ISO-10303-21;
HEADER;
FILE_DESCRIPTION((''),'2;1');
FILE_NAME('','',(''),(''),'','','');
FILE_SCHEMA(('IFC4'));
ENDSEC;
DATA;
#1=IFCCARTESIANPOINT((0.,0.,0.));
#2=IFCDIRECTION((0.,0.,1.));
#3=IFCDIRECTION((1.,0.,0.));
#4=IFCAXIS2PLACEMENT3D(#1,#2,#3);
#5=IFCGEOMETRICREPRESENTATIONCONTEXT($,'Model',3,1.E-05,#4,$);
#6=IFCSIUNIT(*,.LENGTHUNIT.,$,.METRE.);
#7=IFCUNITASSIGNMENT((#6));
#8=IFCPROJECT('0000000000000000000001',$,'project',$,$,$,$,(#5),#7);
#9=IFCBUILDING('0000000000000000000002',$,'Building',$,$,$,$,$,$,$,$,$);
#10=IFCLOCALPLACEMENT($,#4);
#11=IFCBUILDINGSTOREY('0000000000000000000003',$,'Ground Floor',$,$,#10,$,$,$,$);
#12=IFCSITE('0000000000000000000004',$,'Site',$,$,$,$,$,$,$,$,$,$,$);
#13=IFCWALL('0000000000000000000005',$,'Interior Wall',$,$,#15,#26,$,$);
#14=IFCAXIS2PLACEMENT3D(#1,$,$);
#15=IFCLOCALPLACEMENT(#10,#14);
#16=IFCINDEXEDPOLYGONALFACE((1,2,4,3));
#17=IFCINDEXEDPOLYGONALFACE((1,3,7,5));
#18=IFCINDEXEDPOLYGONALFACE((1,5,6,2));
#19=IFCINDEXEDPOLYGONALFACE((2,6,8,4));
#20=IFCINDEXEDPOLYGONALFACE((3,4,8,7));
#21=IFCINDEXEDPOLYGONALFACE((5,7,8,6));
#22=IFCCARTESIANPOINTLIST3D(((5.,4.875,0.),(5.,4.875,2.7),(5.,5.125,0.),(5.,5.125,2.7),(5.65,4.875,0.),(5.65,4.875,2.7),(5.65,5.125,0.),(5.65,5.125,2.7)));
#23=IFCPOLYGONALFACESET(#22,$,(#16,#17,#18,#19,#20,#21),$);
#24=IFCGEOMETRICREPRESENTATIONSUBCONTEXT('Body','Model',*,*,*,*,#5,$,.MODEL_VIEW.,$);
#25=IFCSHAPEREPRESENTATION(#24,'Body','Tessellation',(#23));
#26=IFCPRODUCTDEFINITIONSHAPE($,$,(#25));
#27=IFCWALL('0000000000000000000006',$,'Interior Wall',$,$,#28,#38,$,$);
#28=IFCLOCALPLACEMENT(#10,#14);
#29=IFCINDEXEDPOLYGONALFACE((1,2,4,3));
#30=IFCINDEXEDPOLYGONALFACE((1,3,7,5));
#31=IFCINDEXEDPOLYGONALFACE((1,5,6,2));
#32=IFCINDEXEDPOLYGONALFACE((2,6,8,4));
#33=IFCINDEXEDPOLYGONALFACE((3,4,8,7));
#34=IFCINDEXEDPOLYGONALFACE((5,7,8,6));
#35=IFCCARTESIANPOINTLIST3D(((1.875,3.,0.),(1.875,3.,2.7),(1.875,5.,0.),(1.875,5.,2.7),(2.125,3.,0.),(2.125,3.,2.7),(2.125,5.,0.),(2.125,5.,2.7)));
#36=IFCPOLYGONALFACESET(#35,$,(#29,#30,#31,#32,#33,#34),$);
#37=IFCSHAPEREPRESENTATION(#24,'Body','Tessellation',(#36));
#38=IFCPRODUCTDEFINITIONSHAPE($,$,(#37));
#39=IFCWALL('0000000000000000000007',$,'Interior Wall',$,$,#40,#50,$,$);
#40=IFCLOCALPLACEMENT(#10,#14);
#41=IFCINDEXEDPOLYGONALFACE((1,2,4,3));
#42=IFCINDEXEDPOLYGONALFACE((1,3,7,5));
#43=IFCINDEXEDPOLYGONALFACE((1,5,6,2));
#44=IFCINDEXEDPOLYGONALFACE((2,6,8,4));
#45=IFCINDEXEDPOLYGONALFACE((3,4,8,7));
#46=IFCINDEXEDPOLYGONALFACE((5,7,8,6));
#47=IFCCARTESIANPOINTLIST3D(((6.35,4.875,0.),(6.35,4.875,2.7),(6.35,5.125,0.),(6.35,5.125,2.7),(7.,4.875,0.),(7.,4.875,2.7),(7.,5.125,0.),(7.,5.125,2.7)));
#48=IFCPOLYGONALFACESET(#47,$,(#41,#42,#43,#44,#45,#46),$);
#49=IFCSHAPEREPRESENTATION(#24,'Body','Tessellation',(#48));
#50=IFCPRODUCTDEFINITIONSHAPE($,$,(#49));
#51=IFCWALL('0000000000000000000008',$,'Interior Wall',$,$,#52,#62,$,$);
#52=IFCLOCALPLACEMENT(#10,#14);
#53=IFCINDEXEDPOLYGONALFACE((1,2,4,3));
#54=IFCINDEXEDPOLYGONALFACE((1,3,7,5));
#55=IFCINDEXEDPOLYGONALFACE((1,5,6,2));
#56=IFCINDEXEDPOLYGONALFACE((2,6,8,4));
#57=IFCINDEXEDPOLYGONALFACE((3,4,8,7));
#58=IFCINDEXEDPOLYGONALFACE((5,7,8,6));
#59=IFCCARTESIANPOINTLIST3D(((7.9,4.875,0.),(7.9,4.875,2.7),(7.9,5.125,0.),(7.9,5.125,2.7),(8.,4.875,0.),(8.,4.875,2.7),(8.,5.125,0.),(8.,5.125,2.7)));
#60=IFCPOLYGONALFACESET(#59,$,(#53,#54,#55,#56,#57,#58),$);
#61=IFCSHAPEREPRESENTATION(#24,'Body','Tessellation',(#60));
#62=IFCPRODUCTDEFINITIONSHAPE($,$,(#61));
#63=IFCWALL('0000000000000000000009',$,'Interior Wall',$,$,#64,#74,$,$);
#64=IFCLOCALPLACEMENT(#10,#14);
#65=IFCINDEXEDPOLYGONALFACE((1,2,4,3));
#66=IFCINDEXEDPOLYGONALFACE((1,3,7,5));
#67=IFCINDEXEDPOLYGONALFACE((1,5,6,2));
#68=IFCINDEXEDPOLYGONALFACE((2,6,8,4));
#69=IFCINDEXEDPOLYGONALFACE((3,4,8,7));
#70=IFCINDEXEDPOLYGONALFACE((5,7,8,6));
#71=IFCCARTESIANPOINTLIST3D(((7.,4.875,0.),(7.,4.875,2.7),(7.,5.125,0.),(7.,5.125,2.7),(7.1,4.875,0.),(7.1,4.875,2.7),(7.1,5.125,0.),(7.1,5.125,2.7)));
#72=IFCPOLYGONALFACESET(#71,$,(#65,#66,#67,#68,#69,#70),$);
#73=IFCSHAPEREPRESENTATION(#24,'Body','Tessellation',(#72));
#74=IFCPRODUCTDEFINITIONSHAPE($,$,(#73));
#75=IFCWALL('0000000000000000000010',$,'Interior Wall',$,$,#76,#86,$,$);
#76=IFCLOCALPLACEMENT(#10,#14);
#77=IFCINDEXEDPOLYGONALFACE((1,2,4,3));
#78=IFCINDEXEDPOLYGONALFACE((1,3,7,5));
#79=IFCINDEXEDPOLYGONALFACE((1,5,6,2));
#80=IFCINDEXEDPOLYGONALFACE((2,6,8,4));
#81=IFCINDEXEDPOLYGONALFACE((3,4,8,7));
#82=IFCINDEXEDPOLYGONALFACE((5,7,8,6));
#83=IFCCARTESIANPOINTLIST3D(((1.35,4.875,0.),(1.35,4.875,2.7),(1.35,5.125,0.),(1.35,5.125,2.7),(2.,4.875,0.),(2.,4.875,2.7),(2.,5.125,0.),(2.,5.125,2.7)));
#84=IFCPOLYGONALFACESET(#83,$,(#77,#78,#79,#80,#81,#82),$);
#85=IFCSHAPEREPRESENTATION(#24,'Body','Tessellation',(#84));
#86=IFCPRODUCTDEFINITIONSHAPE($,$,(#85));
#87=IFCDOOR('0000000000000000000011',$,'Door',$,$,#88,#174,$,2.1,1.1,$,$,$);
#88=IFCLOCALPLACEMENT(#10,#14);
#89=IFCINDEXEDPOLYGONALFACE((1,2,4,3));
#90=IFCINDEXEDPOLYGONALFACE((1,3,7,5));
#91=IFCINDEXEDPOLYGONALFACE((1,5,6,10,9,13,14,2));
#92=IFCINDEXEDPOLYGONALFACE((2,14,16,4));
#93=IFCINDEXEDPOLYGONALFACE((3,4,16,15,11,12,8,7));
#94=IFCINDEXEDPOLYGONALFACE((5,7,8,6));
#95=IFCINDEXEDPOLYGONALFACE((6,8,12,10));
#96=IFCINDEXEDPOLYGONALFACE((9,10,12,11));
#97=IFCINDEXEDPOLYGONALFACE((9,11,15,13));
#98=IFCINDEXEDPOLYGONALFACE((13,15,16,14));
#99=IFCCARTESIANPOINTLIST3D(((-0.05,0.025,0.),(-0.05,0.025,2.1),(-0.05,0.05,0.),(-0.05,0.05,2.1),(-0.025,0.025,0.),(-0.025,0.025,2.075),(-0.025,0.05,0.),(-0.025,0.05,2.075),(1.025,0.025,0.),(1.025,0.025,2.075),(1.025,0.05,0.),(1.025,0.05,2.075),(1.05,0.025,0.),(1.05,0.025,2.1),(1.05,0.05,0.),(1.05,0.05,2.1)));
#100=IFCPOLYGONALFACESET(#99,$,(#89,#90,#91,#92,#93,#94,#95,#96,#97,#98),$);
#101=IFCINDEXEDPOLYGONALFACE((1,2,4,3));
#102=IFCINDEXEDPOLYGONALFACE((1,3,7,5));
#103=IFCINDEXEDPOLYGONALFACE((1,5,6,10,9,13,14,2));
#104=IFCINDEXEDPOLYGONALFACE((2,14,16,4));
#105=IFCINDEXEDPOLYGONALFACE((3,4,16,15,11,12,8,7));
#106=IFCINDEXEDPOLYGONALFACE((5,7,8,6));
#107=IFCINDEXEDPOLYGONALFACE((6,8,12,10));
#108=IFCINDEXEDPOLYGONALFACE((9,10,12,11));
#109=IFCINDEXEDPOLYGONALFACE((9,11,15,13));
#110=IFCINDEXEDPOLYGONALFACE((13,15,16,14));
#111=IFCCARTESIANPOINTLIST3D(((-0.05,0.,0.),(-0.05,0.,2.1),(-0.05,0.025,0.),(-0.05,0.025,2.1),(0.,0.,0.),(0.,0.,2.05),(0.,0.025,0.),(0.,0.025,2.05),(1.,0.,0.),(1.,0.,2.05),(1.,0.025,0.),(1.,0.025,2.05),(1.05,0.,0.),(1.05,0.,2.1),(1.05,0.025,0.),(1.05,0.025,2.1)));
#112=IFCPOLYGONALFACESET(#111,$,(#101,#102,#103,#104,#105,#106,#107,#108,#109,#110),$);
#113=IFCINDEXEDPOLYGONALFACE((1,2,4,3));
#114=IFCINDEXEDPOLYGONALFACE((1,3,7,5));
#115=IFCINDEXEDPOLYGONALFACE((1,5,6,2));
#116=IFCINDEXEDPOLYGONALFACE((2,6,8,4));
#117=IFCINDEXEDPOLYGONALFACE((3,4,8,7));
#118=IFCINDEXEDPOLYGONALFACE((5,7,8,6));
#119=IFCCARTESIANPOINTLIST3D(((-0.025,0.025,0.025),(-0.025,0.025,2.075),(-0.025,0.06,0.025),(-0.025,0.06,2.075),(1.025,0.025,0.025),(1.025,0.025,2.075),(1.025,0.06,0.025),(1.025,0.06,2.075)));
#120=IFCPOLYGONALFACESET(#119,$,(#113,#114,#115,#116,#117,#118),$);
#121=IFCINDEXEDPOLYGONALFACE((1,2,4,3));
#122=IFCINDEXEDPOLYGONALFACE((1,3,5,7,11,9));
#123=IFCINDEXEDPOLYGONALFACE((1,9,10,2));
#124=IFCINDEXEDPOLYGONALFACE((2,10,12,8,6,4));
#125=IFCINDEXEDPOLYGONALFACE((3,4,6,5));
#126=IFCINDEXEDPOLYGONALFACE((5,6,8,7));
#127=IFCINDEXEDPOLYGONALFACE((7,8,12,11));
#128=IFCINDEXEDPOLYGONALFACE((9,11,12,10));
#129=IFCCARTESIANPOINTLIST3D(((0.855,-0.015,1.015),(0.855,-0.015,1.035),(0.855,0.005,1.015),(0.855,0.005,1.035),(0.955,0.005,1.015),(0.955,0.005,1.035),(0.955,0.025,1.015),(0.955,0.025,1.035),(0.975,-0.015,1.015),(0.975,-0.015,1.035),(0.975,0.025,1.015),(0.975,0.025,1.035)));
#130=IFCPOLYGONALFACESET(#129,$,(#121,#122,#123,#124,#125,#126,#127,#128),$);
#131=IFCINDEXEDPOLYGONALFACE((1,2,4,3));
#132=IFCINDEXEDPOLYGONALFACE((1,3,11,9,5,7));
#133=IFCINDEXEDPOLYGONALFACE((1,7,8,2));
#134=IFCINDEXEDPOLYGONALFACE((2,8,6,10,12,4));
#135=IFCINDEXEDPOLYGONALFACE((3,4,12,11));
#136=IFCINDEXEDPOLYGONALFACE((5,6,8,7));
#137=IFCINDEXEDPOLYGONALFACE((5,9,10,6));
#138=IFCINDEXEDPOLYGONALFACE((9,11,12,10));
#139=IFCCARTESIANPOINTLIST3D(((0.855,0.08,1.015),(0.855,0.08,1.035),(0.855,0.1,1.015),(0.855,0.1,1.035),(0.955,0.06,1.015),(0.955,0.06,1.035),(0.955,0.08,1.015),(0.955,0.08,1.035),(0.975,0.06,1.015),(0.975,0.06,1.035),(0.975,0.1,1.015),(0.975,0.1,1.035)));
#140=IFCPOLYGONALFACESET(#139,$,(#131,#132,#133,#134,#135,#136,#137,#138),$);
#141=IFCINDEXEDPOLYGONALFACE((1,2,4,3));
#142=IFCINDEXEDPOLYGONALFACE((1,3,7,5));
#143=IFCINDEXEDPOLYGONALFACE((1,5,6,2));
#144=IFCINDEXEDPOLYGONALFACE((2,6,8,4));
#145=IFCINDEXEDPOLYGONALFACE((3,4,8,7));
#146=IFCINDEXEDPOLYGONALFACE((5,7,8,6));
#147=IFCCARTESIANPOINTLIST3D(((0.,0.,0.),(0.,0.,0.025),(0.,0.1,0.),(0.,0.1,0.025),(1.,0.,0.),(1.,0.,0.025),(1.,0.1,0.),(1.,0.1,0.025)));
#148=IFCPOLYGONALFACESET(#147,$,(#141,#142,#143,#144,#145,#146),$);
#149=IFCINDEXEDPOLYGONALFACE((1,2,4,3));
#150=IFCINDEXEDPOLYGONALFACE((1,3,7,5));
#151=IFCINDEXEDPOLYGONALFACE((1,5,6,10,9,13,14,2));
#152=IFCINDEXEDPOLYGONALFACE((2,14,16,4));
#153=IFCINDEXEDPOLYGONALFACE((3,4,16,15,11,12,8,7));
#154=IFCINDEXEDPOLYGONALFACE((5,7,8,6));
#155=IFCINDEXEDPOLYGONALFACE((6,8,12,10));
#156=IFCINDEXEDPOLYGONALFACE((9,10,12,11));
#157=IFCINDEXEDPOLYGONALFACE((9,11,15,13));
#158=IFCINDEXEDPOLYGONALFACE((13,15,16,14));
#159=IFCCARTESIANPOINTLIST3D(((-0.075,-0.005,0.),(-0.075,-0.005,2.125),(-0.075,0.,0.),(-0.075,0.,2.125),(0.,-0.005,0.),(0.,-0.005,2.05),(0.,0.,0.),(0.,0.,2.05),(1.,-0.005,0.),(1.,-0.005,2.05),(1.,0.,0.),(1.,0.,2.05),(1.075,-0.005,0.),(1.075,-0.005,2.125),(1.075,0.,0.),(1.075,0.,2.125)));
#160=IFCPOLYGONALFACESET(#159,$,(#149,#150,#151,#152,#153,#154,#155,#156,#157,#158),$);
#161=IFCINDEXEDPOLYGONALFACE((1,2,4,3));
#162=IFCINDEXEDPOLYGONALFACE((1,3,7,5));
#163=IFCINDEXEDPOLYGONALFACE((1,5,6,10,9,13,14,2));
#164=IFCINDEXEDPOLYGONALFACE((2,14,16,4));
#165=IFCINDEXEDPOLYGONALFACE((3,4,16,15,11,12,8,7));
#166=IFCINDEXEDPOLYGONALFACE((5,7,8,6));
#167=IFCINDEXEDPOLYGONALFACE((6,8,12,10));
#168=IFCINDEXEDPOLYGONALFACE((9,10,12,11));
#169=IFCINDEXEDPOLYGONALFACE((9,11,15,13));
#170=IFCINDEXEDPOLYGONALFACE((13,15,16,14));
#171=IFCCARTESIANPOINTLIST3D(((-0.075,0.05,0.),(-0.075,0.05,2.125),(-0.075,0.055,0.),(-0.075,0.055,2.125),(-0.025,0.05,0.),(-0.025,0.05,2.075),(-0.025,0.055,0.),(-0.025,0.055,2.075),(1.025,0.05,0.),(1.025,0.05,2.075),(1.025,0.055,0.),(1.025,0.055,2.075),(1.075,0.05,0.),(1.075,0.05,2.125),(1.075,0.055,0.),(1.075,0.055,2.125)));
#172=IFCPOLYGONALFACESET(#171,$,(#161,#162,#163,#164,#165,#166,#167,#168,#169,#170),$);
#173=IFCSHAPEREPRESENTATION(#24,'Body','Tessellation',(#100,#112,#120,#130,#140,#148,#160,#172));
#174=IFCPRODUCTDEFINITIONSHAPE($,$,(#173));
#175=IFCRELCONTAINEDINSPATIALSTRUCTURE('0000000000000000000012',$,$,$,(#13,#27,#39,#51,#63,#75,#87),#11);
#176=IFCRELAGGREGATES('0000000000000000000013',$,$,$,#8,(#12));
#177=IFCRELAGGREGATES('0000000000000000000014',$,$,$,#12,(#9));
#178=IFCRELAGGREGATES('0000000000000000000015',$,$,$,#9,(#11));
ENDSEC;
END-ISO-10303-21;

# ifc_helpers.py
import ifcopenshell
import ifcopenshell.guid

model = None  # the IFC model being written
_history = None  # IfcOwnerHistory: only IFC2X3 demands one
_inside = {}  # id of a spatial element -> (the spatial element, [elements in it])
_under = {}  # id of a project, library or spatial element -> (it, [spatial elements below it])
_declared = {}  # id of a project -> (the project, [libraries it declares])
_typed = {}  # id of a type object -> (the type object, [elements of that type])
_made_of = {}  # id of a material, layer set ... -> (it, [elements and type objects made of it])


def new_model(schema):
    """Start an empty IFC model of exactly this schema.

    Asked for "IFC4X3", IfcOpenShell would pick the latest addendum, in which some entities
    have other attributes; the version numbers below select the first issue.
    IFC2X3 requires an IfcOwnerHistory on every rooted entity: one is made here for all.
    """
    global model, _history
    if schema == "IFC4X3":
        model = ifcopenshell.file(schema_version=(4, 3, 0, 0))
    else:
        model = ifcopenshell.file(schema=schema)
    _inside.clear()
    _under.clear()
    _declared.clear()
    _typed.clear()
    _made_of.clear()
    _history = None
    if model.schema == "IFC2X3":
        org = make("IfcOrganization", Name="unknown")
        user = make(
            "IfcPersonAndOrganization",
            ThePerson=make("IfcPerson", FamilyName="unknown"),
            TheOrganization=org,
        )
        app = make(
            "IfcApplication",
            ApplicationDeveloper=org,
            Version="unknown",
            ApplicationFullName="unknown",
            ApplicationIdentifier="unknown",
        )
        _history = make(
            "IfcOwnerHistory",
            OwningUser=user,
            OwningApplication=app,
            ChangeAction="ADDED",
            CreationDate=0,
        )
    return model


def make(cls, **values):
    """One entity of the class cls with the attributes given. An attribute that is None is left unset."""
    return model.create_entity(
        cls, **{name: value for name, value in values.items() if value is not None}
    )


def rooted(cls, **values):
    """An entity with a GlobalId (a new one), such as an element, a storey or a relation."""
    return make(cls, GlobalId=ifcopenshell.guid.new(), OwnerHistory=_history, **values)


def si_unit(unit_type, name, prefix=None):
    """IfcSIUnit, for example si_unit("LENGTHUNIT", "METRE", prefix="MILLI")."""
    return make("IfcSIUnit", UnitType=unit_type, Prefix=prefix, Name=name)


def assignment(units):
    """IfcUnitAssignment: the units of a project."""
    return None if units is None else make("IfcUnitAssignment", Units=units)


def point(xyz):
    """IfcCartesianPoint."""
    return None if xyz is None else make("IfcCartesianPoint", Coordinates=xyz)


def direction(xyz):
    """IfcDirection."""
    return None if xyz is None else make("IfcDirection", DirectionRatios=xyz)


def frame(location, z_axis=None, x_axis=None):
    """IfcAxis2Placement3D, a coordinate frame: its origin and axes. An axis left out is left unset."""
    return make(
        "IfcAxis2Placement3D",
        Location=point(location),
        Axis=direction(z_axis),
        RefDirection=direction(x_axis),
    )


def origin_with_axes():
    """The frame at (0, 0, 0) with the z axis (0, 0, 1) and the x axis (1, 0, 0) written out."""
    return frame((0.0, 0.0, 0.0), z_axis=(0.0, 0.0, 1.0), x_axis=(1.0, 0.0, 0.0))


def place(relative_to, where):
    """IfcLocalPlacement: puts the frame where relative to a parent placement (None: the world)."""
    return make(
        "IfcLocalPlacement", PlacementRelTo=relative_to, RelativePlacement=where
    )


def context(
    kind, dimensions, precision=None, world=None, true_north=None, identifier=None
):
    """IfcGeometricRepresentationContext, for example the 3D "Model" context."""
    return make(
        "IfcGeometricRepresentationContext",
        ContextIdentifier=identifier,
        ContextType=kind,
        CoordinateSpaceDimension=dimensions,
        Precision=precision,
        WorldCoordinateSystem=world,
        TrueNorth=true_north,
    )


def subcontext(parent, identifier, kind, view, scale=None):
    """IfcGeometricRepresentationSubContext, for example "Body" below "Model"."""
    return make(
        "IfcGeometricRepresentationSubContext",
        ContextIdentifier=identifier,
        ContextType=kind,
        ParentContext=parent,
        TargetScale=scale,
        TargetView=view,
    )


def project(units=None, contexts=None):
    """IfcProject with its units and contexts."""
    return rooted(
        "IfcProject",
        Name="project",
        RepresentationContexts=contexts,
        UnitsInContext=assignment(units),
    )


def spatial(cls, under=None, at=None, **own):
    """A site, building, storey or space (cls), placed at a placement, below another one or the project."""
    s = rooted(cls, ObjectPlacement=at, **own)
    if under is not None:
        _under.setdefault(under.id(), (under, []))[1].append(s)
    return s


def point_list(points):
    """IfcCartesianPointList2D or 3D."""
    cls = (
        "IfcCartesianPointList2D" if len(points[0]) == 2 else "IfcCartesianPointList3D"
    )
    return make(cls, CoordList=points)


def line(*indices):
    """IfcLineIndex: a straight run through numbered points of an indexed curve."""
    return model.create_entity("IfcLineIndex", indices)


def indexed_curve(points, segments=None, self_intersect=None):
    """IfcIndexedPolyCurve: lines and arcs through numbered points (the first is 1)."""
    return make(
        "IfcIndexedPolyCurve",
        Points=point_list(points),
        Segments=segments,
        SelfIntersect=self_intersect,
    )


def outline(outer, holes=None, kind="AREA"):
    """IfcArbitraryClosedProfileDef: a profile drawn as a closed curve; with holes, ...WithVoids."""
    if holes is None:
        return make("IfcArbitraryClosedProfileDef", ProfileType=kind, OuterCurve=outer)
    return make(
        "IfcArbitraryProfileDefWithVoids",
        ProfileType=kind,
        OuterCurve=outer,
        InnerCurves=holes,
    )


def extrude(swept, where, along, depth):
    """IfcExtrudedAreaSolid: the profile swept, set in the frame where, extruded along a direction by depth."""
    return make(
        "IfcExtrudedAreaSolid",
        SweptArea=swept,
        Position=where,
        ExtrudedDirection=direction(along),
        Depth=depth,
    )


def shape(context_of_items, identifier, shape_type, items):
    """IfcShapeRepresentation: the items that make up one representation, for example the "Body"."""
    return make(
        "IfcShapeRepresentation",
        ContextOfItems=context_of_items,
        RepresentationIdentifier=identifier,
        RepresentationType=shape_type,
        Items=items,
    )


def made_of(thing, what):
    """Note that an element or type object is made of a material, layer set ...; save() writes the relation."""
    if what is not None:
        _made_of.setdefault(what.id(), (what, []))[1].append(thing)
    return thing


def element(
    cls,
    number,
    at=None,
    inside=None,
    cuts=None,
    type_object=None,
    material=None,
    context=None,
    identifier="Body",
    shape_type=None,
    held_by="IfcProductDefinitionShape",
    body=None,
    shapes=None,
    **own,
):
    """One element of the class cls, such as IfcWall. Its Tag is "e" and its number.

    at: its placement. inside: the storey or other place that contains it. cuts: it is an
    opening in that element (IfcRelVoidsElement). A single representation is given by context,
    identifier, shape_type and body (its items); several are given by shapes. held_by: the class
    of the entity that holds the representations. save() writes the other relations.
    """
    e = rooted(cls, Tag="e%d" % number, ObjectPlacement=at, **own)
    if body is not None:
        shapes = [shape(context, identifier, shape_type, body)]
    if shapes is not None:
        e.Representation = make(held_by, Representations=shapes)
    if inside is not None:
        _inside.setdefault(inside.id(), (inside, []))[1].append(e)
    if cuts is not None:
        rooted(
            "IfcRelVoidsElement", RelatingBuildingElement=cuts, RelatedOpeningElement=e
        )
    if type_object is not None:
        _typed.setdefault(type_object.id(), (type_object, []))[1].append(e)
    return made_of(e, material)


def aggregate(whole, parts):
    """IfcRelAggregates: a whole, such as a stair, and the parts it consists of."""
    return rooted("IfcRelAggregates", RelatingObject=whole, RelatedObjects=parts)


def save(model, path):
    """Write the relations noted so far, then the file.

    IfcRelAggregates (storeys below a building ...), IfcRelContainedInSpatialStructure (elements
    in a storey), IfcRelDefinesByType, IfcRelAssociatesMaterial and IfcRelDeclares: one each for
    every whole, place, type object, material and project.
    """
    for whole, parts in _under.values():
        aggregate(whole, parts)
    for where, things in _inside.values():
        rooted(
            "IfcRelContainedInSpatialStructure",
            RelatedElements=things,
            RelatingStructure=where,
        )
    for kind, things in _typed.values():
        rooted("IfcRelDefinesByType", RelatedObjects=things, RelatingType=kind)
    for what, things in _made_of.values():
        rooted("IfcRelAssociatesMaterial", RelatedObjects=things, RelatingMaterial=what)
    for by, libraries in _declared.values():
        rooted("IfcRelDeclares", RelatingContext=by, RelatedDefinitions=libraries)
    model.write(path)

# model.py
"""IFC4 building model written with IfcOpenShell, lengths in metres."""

from ifc_helpers import new_model, si_unit, frame, origin_with_axes, place, context, subcontext, project, spatial, line, indexed_curve, outline, extrude, element, save


model = new_model("IFC4")

# Units and contexts
model_context = context("Model", 3, precision=1e-05, world=origin_with_axes())
body_context = subcontext(model_context, "Body", "Model", "MODEL_VIEW")
ifc_project = project(units=[si_unit("LENGTHUNIT", "METRE")], contexts=[model_context])

# Site, building, storey
site = spatial("IfcSite", under=ifc_project, Name="Site")
building = spatial("IfcBuilding", under=site, Name="Building")
storey_placement = place(None, origin_with_axes())
storey = spatial("IfcBuildingStorey", under=building, at=storey_placement, Name="Ground Floor")

# Walls
wall_1_placement = place(storey_placement, frame((5.65, 5.0, 0.0), z_axis=(0.0, 0.0, 1.0), x_axis=(-1.0, 0.0, 0.0)))
element("IfcWall", 1, at=wall_1_placement, inside=storey, Name="Interior Wall", context=body_context, shape_type="SweptSolid", body=[
    extrude(outline(indexed_curve([(0.0, 0.0), (0.0, 0.25), (0.65, 0.25), (0.65, 0.0), (0.0, 0.0)], self_intersect=False)), frame((0.0, -0.125, 0.0), z_axis=(0.0, 0.0, 1.0), x_axis=(1.0, 0.0, 0.0)), (0.0, 0.0, 1.0), 2.7),
])
wall_2_placement = place(storey_placement, frame((2.0, 5.0, 0.0), z_axis=(0.0, 0.0, 1.0), x_axis=(0.0, -1.0, 0.0)))
element("IfcWall", 2, at=wall_2_placement, inside=storey, Name="Interior Wall", context=body_context, shape_type="SweptSolid", body=[
    extrude(outline(indexed_curve([(0.0, 0.0), (0.0, 0.25), (2.0, 0.25), (2.0, 0.0), (0.0, 0.0)], self_intersect=False)), frame((0.0, -0.125, 0.0), z_axis=(0.0, 0.0, 1.0), x_axis=(1.0, 0.0, 0.0)), (0.0, 0.0, 1.0), 2.7),
])
wall_3_placement = place(storey_placement, frame((7.0, 5.0, 0.0), z_axis=(0.0, 0.0, 1.0), x_axis=(-1.0, 0.0, 0.0)))
element("IfcWall", 3, at=wall_3_placement, inside=storey, Name="Interior Wall", context=body_context, shape_type="SweptSolid", body=[
    extrude(outline(indexed_curve([(0.0, 0.0), (0.0, 0.25), (0.65, 0.25), (0.65, 0.0), (0.0, 0.0)], self_intersect=False)), frame((0.0, -0.125, 0.0), z_axis=(0.0, 0.0, 1.0), x_axis=(1.0, 0.0, 0.0)), (0.0, 0.0, 1.0), 2.7),
])
for number, where, z_axis, x_axis, name in (
    (4, (8.0, 5.0, 0.0), (0.0, 0.0, 1.0), (-1.0, 0.0, 0.0), "Interior Wall"),
    (5, (7.1, 5.0, 0.0), (0.0, 0.0, 1.0), (-1.0, 0.0, 0.0), "Interior Wall"),
):
    element("IfcWall", number, at=place(storey_placement, frame(where, z_axis=z_axis, x_axis=x_axis)), inside=storey, Name=name, context=body_context, shape_type="SweptSolid", body=[
        extrude(outline(indexed_curve([(0.0, 0.0), (0.0, 0.25), (0.1, 0.25), (0.1, 0.0), (0.0, 0.0)], self_intersect=False)), frame((0.0, -0.125, 0.0), z_axis=(0.0, 0.0, 1.0), x_axis=(1.0, 0.0, 0.0)), (0.0, 0.0, 1.0), 2.7),
    ])
wall_4_placement = place(storey_placement, frame((2.0, 5.0, 0.0), z_axis=(0.0, 0.0, 1.0), x_axis=(-1.0, 0.0, 0.0)))
element("IfcWall", 6, at=wall_4_placement, inside=storey, Name="Interior Wall", context=body_context, shape_type="SweptSolid", body=[
    extrude(outline(indexed_curve([(0.0, 0.0), (0.0, 0.25), (0.65, 0.25), (0.65, 0.0), (0.0, 0.0)], self_intersect=False)), frame((0.0, -0.125, 0.0), z_axis=(0.0, 0.0, 1.0), x_axis=(1.0, 0.0, 0.0)), (0.0, 0.0, 1.0), 2.7),
])

# Door
door_1_placement = place(storey_placement, frame((-0.05, 0.0, 0.0), z_axis=(0.0, 0.0, 1.0), x_axis=(1.0, 0.0, 0.0)))
element("IfcDoor", 7, at=door_1_placement, inside=storey, Name="Door", OverallHeight=2.1, OverallWidth=1.1, context=body_context, shape_type="SweptSolid", body=[
    extrude(outline(indexed_curve([(0.0, 0.0), (0.0, 2.1), (1.1, 2.1), (1.1, 0.0), (1.075, 0.0), (1.075, 2.075), (0.025, 2.075), (0.025, 0.0)], segments=[line(1, 2, 3, 4, 5, 6, 7, 8, 1)])), frame((0.0, 0.025, 0.0), z_axis=(0.0, -1.0, 0.0), x_axis=(1.0, 0.0, 0.0)), (0.0, 0.0, -1.0), 0.025),
    extrude(outline(indexed_curve([(0.0, 0.0), (0.0, 2.1), (1.1, 2.1), (1.1, 0.0), (1.05, 0.0), (1.05, 2.05), (0.05, 2.05), (0.05, 0.0)], segments=[line(1, 2, 3, 4, 5, 6, 7, 8, 1)])), frame((0.0, 0.0, 0.0), z_axis=(0.0, -1.0, 0.0), x_axis=(1.0, 0.0, 0.0)), (0.0, 0.0, -1.0), 0.025),
    extrude(outline(indexed_curve([(0.0, 0.0), (1.05, 0.0), (1.05, 0.035), (0.0, 0.035)], segments=[line(1, 2, 3, 4, 1)])), frame((0.025, 0.025, 0.025), z_axis=(0.0, 0.0, 1.0), x_axis=(1.0, 0.0, 0.0)), (0.0, 0.0, 1.0), 2.05),
    extrude(outline(indexed_curve([(0.0, 0.0), (0.0, -0.04), (-0.12, -0.04), (-0.12, -0.02), (-0.02, -0.02), (-0.02, 0.0)], segments=[line(1, 2, 3, 4, 5, 6, 1)])), frame((1.025, 0.025, 1.015), z_axis=(0.0, 0.0, 1.0), x_axis=(1.0, 0.0, 0.0)), (0.0, 0.0, 1.0), 0.02),
    extrude(outline(indexed_curve([(0.0, 0.0), (0.0, 0.04), (-0.12, 0.04), (-0.12, 0.02), (-0.02, 0.02), (-0.02, 0.0)], segments=[line(1, 2, 3, 4, 5, 6, 1)])), frame((1.025, 0.06, 1.015), z_axis=(0.0, 0.0, 1.0), x_axis=(1.0, 0.0, 0.0)), (0.0, 0.0, 1.0), 0.02),
    extrude(outline(indexed_curve([(0.0, 0.0), (1.0, 0.0), (1.0, 0.1), (0.0, 0.1)], segments=[line(1, 2, 3, 4, 1)])), frame((0.05, 0.0, 0.0), z_axis=(0.0, 0.0, 1.0), x_axis=(1.0, 0.0, 0.0)), (0.0, 0.0, 1.0), 0.025),
    extrude(outline(indexed_curve([(0.0, 0.0), (0.0, 2.125), (1.15, 2.125), (1.15, 0.0), (1.075, 0.0), (1.075, 2.05), (0.075, 2.05), (0.075, 0.0)], segments=[line(1, 2, 3, 4, 5, 6, 7, 8, 1)])), frame((-0.025, -0.005, 0.0), z_axis=(0.0, -1.0, 0.0), x_axis=(1.0, 0.0, 0.0)), (0.0, 0.0, -1.0), 0.005),
    extrude(outline(indexed_curve([(0.0, 0.0), (0.0, 2.125), (1.15, 2.125), (1.15, 0.0), (1.1, 0.0), (1.1, 2.075), (0.05, 2.075), (0.05, 0.0)], segments=[line(1, 2, 3, 4, 5, 6, 7, 8, 1)])), frame((-0.025, 0.05, 0.0), z_axis=(0.0, -1.0, 0.0), x_axis=(1.0, 0.0, 0.0)), (0.0, 0.0, -1.0), 0.005),
])

save(model, "model.ifc")
